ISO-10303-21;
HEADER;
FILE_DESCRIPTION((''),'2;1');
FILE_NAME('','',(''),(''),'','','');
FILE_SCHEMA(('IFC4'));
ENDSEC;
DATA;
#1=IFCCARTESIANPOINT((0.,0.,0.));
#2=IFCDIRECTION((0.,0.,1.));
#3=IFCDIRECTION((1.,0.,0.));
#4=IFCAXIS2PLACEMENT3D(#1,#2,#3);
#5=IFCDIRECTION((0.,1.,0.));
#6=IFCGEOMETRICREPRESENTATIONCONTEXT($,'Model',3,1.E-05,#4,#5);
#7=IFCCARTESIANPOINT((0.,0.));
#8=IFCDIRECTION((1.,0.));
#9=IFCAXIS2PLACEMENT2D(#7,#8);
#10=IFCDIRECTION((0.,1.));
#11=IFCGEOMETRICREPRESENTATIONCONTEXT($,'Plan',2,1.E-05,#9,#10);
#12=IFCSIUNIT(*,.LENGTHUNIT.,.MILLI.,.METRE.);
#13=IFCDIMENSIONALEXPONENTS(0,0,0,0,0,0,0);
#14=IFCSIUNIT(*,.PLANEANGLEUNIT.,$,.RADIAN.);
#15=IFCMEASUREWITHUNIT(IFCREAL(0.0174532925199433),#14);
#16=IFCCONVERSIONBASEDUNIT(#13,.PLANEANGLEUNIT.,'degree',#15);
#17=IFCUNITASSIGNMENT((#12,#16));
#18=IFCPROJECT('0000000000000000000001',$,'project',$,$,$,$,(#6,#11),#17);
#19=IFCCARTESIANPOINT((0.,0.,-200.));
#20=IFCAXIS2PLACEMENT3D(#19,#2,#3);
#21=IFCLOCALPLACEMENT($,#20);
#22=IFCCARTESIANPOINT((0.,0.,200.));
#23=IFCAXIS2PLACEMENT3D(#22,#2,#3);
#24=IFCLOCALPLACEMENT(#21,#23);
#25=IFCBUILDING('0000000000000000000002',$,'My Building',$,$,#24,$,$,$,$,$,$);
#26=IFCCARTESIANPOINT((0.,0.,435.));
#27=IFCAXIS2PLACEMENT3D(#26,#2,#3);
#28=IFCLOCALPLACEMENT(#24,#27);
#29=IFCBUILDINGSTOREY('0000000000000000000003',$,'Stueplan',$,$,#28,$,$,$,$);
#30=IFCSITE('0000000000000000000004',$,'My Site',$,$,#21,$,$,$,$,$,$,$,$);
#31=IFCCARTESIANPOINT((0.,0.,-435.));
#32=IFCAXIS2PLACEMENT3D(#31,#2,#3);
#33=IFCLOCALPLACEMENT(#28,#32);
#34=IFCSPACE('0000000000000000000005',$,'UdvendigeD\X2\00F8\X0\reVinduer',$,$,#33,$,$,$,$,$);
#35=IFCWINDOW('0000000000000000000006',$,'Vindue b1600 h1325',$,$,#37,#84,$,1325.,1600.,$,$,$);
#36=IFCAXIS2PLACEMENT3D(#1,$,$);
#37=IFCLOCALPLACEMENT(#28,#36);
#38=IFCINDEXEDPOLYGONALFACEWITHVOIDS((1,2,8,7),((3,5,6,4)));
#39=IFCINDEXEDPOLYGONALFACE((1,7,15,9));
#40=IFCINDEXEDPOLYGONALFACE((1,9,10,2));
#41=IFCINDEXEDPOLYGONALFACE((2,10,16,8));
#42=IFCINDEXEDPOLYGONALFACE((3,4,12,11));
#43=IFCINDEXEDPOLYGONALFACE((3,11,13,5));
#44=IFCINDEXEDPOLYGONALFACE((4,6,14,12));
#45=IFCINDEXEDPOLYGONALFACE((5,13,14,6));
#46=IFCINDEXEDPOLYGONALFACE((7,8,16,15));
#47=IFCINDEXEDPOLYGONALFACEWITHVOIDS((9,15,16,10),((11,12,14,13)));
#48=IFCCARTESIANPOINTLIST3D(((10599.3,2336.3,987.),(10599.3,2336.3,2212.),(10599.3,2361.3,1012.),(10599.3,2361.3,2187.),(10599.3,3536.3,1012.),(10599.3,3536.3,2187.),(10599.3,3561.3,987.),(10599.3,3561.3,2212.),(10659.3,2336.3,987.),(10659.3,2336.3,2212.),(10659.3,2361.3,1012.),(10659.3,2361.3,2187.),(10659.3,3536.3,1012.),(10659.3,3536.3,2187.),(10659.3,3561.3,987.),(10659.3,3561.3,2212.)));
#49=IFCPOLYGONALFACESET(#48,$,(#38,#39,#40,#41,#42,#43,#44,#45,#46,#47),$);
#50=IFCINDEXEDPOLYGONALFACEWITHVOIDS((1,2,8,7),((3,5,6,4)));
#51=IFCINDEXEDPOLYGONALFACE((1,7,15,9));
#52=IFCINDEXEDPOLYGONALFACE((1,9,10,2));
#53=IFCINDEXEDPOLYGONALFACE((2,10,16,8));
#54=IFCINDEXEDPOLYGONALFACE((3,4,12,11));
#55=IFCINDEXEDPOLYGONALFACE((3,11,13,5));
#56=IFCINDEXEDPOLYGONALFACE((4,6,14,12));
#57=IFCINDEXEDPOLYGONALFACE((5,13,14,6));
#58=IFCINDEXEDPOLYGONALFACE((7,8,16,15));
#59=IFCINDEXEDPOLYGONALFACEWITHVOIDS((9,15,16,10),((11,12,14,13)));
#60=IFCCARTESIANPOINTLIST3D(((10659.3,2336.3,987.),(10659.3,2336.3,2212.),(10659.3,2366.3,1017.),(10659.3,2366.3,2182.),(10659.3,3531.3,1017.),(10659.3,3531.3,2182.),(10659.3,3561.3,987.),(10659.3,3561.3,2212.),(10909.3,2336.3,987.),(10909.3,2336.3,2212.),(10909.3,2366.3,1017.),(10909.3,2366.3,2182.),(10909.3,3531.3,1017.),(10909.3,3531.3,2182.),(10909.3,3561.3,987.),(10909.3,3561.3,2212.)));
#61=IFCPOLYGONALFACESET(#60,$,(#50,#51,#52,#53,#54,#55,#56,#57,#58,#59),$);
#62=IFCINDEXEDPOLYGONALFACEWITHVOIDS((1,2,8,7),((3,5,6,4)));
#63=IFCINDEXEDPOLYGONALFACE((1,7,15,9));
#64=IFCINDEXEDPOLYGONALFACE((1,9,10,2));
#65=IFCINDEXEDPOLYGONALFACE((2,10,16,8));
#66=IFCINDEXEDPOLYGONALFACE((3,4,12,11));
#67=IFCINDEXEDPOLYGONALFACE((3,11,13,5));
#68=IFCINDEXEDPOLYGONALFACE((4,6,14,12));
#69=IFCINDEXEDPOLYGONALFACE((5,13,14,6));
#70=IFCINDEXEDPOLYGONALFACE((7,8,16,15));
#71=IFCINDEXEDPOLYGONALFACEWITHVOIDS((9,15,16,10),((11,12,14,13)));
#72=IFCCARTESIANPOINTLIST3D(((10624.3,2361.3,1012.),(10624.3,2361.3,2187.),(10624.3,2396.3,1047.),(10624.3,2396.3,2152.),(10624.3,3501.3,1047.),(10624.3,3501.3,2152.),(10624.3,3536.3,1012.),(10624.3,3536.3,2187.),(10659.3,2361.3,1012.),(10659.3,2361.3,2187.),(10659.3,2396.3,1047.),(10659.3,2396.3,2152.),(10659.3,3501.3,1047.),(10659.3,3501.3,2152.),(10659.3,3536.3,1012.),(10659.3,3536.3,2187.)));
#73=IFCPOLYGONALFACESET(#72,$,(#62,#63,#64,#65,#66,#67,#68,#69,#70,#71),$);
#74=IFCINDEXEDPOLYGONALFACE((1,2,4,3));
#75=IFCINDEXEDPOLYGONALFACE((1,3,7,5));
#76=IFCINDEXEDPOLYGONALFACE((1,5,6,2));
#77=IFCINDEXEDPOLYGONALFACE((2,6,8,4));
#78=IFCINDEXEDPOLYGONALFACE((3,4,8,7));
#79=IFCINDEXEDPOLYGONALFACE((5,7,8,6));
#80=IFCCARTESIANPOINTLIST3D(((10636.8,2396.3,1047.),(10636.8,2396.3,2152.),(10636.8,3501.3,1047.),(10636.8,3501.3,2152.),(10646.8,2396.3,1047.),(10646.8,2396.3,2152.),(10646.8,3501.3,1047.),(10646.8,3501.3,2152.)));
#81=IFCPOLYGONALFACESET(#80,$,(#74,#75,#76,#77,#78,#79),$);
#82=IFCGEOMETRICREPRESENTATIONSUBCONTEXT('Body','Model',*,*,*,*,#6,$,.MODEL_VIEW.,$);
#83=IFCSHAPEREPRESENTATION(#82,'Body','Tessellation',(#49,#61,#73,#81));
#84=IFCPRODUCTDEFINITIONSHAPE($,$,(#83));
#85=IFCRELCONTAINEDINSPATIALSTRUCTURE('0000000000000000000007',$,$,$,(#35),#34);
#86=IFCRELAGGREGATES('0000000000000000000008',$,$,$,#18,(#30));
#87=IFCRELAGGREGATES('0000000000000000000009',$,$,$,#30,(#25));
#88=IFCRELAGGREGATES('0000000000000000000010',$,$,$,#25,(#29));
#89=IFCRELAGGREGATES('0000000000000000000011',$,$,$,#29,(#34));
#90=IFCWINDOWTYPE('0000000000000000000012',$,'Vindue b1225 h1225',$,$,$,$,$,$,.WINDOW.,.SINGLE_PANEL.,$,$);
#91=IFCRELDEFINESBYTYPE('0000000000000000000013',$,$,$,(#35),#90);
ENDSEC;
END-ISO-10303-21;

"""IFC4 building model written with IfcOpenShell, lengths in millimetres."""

from ifc_helpers import new_model, entity, si_unit, converted_unit, direction, frame, origin_with_axes, origin_2d_with_axis, place, context, subcontext, project, spatial, line, indexed_curve, outline, extrude, shape, source, transform, mapped, type_object, type_shapes, element, save


model = new_model("IFC4")

# Units and contexts
model_context = context("Model", 3, precision=1e-05, world=origin_with_axes(), true_north=direction((0.0, 1.0, 0.0)))
plan_context = context("Plan", 2, precision=1e-05, world=origin_2d_with_axis(), true_north=direction((0.0, 1.0)))
body_context_1 = subcontext(model_context, "Body", "Model", "MODEL_VIEW")
body_context_2 = subcontext(plan_context, "Body", "Plan", "PLAN_VIEW")
ifc_project = project(units=[si_unit("LENGTHUNIT", "METRE", prefix="MILLI"), converted_unit("PLANEANGLEUNIT", "degree", entity("IfcReal", 0.0174532925199433), si_unit("PLANEANGLEUNIT", "RADIAN"), dimensions=[0, 0, 0, 0, 0, 0, 0])], contexts=[model_context, plan_context])

# Site, building, storey
site_placement = place(None, frame((0.0, 0.0, -200.0), z_axis=(0.0, 0.0, 1.0), x_axis=(1.0, 0.0, 0.0)))
site = spatial("IfcSite", under=ifc_project, at=site_placement, Name="My Site")
building_placement = place(site_placement, frame((0.0, 0.0, 200.0), z_axis=(0.0, 0.0, 1.0), x_axis=(1.0, 0.0, 0.0)))
building = spatial("IfcBuilding", under=site, at=building_placement, Name="My Building")
storey_placement = place(building_placement, frame((0.0, 0.0, 435.0), z_axis=(0.0, 0.0, 1.0), x_axis=(1.0, 0.0, 0.0)))
storey = spatial("IfcBuildingStorey", under=building, at=storey_placement, Name="Stueplan")

# Shared definitions
space_1_placement = place(storey_placement, frame((0.0, 0.0, -435.0), z_axis=(0.0, 0.0, 1.0), x_axis=(1.0, 0.0, 0.0)))
space_1 = spatial("IfcSpace", under=storey, at=space_1_placement, Name="UdvendigeDøreVinduer")

# Window
window_type_1 = type_object("IfcWindowType", Name="Vindue b1225 h1225", PartitioningType="SINGLE_PANEL", PredefinedType="WINDOW")
shared_shape_1 = source(origin_with_axes(), body_context_1, "Body", "SweptSolid", [
    extrude(outline(indexed_curve([(0.0, 0.0), (1225.0, 0.0), (1225.0, 1225.0), (0.0, 1225.0)], segments=[line(1, 2, 3, 4, 1)]), holes=[indexed_curve([(25.0, 25.0), (1200.0, 25.0), (1200.0, 1200.0), (25.0, 1200.0)], segments=[line(1, 2, 3, 4, 1)])]), frame((0.0, 250.0, 0.0), z_axis=(0.0, -1.0, 0.0), x_axis=(1.0, 0.0, 0.0)), (0.0, 0.0, -1.0), 60.0),
    extrude(outline(indexed_curve([(0.0, 0.0), (1225.0, 0.0), (1225.0, 1225.0), (0.0, 1225.0)], segments=[line(1, 2, 3, 4, 1)]), holes=[indexed_curve([(30.0, 30.0), (1195.0, 30.0), (1195.0, 1195.0), (30.0, 1195.0)], segments=[line(1, 2, 3, 4, 1)])]), frame((0.0, 0.0, 0.0), z_axis=(0.0, -1.0, 0.0), x_axis=(1.0, 0.0, 0.0)), (0.0, 0.0, -1.0), 250.0),
    extrude(outline(indexed_curve([(0.0, 0.0), (1175.0, 0.0), (1175.0, 1175.0), (0.0, 1175.0)], segments=[line(1, 2, 3, 4, 1)]), holes=[indexed_curve([(35.0, 35.0), (1140.0, 35.0), (1140.0, 1140.0), (35.0, 1140.0)], segments=[line(1, 2, 3, 4, 1)])]), frame((25.0, 250.0, 25.0), z_axis=(0.0, -1.0, 0.0), x_axis=(1.0, 0.0, 0.0)), (0.0, 0.0, -1.0), 35.0),
    extrude(outline(indexed_curve([(35.0, 35.0), (1140.0, 35.0), (1140.0, 1140.0), (35.0, 1140.0)], segments=[line(1, 2, 3, 4, 1)])), frame((25.0, 262.5, 25.0), z_axis=(0.0, -1.0, 0.0), x_axis=(1.0, 0.0, 0.0)), (0.0, 0.0, -1.0), 10.0),
])
shared_shape_2 = source(origin_with_axes(), body_context_2, "Body", "Curve2D", [
    entity("IfcIndexedPolyCurve", entity("IfcCartesianPointList2D", [[30.0, 0.0], [1195.0, 0.0]])),
    entity("IfcIndexedPolyCurve", entity("IfcCartesianPointList2D", [[0.0, 310.0], [25.0, 310.0], [25.0, 250.0], [30.0, 250.0], [30.0, 0.0], [0.0, 0.0]]), [entity("IfcLineIndex", [1, 2, 3, 4, 5, 6, 1])]),
    entity("IfcIndexedPolyCurve", entity("IfcCartesianPointList2D", [[1225.0, 310.0], [1200.0, 310.0], [1200.0, 250.0], [1195.0, 250.0], [1195.0, 0.0], [1225.0, 0.0]]), [entity("IfcLineIndex", [1, 2, 3, 4, 5, 6, 1])]),
    entity("IfcIndexedPolyCurve", entity("IfcCartesianPointList2D", [[25.0, 250.0], [60.0, 250.0], [60.0, 285.0], [25.0, 285.0]]), [entity("IfcLineIndex", [1, 2, 3, 4, 1])]),
    entity("IfcIndexedPolyCurve", entity("IfcCartesianPointList2D", [[1200.0, 250.0], [1165.0, 250.0], [1165.0, 285.0], [1200.0, 285.0]]), [entity("IfcLineIndex", [1, 2, 3, 4, 1])]),
    entity("IfcIndexedPolyCurve", entity("IfcCartesianPointList2D", [[60.0, 250.0], [1165.0, 250.0]])),
    entity("IfcIndexedPolyCurve", entity("IfcCartesianPointList2D", [[60.0, 285.0], [1165.0, 285.0]])),
    entity("IfcIndexedPolyCurve", entity("IfcCartesianPointList2D", [[60.0, 267.5], [1165.0, 267.5]])),
])
type_shapes(window_type_1, [shared_shape_1, shared_shape_2])
window_1_placement = place(space_1_placement, frame((10909.3, 2336.3, 1422.0), z_axis=(0.0, 0.0, 1.0), x_axis=(0.0, 1.0, 0.0)))
element("IfcWindow", 1, at=window_1_placement, inside=space_1, type_object=window_type_1, Name="Vindue b1600 h1325", OverallHeight=1325.0, OverallWidth=1600.0, shapes=[
    shape(body_context_1, "Body", "MappedRepresentation", [mapped(shared_shape_1, transform((0.0, 0.0, 0.0), x_axis=(1.0, 0.0, 0.0), y_axis=(0.0, 1.0, 0.0), z_axis=(0.0, 0.0, 1.0), scale=1.0))]),
    shape(body_context_2, "Body", "MappedRepresentation", [mapped(shared_shape_2, transform((0.0, 0.0, 0.0), x_axis=(1.0, 0.0, 0.0), y_axis=(0.0, 1.0, 0.0), z_axis=(0.0, 0.0, 1.0), scale=1.0))]),
])

save(model, "model.ifc")
